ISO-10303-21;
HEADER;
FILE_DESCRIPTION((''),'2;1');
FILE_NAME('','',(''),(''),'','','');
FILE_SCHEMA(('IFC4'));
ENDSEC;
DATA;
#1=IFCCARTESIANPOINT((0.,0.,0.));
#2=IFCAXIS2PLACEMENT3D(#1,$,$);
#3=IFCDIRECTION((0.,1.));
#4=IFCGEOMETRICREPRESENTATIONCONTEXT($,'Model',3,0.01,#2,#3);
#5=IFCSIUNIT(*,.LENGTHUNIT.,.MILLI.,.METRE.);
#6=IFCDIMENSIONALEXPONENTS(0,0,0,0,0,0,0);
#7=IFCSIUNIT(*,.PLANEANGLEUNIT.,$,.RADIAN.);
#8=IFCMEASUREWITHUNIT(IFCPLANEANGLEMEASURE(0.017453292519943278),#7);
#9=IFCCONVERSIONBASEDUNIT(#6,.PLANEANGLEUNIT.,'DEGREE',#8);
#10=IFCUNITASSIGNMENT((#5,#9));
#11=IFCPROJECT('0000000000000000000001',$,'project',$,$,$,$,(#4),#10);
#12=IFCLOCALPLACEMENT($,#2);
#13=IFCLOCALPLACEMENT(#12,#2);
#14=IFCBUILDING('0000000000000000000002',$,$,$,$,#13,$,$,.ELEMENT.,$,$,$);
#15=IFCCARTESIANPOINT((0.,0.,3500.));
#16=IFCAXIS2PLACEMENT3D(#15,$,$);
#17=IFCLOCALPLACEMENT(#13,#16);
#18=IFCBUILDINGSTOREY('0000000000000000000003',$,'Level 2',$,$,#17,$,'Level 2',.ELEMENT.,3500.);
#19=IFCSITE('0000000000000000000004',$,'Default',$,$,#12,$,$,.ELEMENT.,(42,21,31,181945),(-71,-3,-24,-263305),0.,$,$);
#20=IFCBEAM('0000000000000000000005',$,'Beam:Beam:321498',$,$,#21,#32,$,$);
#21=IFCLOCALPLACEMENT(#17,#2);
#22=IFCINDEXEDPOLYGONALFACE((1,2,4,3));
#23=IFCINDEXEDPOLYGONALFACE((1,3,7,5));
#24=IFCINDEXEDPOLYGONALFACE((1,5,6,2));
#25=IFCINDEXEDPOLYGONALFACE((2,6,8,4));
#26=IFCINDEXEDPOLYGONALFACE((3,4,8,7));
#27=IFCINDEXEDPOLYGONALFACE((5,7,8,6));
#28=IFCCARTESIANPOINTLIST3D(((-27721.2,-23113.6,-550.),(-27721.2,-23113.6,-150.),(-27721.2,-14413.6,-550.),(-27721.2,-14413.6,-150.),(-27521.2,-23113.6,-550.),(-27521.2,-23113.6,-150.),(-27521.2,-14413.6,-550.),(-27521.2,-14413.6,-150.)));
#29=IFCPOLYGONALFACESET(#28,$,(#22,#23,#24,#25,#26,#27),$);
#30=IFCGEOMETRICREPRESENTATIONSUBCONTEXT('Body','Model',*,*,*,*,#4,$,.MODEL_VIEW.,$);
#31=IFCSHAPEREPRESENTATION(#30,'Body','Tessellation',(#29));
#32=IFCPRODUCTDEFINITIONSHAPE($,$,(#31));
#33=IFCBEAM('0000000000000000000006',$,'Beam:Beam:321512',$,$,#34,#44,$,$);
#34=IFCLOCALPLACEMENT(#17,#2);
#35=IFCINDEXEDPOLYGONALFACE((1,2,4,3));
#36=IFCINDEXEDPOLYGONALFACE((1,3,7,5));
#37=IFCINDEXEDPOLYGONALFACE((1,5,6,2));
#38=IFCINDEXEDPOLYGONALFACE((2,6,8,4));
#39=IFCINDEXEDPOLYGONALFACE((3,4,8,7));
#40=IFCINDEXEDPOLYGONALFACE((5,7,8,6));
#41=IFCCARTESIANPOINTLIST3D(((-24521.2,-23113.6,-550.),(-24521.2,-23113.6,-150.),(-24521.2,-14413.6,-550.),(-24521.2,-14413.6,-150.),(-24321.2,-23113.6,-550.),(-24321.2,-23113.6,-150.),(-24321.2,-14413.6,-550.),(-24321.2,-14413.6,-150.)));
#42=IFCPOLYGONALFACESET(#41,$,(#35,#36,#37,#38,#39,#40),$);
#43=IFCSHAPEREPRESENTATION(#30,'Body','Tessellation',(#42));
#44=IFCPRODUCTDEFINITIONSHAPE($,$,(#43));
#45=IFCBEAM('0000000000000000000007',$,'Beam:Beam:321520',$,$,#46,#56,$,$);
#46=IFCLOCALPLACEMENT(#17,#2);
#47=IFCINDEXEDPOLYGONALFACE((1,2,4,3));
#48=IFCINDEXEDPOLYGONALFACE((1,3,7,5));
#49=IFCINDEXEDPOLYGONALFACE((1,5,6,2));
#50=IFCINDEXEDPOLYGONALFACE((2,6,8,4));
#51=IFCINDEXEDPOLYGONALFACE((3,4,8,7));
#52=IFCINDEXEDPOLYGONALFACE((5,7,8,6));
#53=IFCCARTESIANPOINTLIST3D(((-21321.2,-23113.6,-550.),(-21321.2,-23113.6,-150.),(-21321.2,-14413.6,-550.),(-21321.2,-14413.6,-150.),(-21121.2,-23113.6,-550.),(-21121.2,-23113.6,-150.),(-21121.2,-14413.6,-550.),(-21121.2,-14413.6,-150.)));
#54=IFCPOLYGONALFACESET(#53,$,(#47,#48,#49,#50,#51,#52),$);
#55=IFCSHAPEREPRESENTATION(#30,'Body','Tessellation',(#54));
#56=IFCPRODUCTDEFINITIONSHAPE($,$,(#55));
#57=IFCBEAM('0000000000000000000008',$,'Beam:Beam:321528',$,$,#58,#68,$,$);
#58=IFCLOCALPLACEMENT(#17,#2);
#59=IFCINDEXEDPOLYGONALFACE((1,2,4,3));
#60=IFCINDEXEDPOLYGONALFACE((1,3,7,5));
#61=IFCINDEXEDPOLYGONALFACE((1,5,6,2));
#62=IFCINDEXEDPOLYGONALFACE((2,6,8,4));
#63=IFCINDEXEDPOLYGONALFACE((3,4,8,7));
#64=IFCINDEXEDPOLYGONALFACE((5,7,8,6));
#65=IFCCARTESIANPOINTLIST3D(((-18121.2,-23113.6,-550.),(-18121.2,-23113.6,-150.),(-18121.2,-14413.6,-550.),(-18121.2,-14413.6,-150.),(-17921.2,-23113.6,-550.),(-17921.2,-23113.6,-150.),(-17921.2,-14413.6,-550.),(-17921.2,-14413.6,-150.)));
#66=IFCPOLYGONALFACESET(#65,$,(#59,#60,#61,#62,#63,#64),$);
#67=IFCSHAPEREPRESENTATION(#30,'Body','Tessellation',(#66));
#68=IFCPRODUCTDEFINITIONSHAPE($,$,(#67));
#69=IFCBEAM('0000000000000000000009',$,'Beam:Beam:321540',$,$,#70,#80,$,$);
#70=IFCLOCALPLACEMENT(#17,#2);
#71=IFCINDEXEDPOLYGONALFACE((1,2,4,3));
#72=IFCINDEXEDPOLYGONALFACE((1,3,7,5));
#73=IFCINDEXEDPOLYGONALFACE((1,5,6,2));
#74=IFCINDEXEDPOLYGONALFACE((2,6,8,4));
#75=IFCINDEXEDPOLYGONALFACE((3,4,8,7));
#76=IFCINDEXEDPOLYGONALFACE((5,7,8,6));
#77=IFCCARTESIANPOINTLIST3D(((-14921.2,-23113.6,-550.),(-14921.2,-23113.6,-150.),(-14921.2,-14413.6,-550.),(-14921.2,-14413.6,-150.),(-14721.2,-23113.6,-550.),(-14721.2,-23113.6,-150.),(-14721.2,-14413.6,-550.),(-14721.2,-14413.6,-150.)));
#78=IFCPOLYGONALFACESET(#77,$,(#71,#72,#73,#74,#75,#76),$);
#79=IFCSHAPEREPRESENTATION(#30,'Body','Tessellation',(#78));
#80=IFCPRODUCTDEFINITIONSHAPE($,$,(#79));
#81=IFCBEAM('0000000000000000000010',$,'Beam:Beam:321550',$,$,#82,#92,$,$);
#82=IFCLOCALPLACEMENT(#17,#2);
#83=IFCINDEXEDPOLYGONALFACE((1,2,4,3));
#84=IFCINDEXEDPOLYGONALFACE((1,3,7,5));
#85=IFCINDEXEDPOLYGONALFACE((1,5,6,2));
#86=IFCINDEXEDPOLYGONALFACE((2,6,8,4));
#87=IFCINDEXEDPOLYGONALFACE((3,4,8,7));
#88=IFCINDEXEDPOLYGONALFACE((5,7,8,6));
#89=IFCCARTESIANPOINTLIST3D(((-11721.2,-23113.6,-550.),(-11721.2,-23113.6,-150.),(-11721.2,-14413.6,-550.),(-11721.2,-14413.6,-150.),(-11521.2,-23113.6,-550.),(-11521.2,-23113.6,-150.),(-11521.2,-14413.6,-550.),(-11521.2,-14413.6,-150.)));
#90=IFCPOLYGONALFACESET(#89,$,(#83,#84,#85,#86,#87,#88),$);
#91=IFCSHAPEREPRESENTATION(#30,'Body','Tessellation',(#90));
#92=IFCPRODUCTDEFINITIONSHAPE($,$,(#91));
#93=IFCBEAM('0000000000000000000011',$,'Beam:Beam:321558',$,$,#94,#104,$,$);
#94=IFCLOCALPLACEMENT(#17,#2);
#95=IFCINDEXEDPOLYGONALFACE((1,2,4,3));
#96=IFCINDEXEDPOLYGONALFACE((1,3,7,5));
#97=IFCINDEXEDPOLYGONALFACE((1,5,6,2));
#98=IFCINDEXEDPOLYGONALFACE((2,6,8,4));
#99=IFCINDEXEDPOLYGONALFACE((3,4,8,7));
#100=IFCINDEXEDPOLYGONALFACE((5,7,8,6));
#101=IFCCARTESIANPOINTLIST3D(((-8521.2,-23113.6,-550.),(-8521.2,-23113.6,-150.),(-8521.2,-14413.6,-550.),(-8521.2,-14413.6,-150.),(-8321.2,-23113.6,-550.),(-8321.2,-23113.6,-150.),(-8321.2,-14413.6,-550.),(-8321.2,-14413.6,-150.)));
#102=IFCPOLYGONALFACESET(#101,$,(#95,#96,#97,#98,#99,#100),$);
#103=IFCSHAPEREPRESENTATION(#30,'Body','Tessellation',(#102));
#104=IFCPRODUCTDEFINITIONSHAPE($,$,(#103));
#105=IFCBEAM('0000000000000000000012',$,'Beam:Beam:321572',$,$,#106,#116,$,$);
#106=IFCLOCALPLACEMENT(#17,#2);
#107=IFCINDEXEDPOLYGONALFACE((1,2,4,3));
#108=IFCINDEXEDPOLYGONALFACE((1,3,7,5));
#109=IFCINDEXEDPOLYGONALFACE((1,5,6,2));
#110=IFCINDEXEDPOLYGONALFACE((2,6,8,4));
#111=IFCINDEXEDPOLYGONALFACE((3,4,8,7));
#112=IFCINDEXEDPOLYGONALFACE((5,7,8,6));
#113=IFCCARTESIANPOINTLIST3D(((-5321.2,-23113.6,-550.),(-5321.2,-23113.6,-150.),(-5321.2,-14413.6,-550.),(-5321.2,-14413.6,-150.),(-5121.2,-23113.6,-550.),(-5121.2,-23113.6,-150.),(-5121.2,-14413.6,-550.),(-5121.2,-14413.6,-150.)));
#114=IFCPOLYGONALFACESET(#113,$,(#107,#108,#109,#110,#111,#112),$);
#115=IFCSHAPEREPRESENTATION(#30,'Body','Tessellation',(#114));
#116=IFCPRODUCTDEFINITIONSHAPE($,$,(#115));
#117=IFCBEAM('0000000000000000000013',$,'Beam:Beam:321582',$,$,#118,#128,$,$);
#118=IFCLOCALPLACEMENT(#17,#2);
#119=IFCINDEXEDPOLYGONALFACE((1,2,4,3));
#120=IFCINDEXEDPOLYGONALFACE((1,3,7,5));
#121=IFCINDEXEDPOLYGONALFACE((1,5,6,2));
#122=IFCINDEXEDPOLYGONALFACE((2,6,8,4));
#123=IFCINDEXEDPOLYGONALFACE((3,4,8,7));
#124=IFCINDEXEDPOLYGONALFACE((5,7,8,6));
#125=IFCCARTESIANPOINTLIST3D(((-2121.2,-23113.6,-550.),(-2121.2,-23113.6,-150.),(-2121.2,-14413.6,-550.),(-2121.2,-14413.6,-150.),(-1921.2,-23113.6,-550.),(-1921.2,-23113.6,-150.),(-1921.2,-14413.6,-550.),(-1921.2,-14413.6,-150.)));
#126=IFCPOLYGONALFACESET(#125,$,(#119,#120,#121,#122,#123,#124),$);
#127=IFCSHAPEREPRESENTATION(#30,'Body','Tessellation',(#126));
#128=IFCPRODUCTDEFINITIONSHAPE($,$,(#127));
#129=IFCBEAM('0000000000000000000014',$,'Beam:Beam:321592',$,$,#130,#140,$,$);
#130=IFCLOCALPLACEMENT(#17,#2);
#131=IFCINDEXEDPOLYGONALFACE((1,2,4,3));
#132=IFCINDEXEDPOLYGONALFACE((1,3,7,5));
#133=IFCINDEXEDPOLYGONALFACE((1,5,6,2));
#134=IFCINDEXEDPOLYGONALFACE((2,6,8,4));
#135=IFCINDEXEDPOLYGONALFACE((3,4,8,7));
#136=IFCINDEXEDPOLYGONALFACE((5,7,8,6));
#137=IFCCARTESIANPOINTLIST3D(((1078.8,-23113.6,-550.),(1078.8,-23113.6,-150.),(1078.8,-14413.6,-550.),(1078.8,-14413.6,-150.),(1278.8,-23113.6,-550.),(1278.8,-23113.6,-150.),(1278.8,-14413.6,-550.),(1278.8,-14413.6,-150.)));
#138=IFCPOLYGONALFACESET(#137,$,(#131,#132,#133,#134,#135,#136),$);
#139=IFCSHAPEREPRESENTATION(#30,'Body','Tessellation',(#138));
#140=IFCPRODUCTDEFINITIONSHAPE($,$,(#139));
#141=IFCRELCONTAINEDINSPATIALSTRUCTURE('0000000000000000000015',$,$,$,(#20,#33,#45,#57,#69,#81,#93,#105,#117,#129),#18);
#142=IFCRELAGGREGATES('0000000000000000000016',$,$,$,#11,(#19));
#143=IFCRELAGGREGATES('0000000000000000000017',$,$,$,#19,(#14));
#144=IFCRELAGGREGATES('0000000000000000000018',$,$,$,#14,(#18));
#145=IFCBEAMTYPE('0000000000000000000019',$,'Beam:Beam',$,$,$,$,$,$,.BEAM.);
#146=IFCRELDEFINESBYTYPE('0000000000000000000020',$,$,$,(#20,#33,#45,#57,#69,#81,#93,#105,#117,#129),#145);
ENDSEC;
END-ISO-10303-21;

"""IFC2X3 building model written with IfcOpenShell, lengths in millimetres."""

from ifc_helpers import new_model, entity, si_unit, converted_unit, direction, frame, frame_2d, origin, place, context, subcontext, project, spatial, rectangle, extrude, type_object, element, save


model = new_model("IFC2X3")

# Units and contexts
model_context = context("Model", 3, precision=0.01, world=origin(), true_north=direction((0.0, 1.0)))
body_context = subcontext(model_context, "Body", "Model", "MODEL_VIEW")
ifc_project = project(units=[si_unit("LENGTHUNIT", "METRE", prefix="MILLI"), converted_unit("PLANEANGLEUNIT", "DEGREE", entity("IfcPlaneAngleMeasure", 0.017453292519943278), si_unit("PLANEANGLEUNIT", "RADIAN"), dimensions=[0, 0, 0, 0, 0, 0, 0])], contexts=[model_context])

# Site, building, storey
site_placement = place(None, origin())
site = spatial("IfcSite", under=ifc_project, at=site_placement, Name="Default", CompositionType="ELEMENT", RefLatitude=(42, 21, 31, 181945), RefLongitude=(-71, -3, -24, -263305), RefElevation=0.0)
building_placement = place(site_placement, origin())
building = spatial("IfcBuilding", under=site, at=building_placement, CompositionType="ELEMENT")
storey_placement = place(building_placement, frame((0.0, 0.0, 3500.0)))
storey = spatial("IfcBuildingStorey", under=building, at=storey_placement, Name="Level 2", LongName="Level 2", CompositionType="ELEMENT", Elevation=3500.0)

# Beams
beam_type = type_object("IfcBeamType", Name="Beam:Beam", PredefinedType="BEAM")
beam_1_placement = place(storey_placement, frame((-27646.2, -14413.6, -150.0), z_axis=(0.0, 0.0, 1.0), x_axis=(0.0, -1.0, 0.0)))
element("IfcBeam", 1, at=beam_1_placement, inside=storey, type_object=beam_type, Name="Beam:Beam:321498", context=body_context, shape_type="SweptSolid", body=[
    extrude(rectangle(XDim=400.0, YDim=200.0, at=frame_2d((0.0, 0.0), x_axis=(1.0, 0.0))), frame((0.0, 25.0, -200.0), z_axis=(1.0, 0.0, 0.0), x_axis=(0.0, 0.0, -1.0)), (0.0, 0.0, 1.0), 8700.0),
])
for number, where, z_axis, x_axis, name in (
    (2, (-24446.2, -14413.6, -150.0), (0.0, 0.0, 1.0), (0.0, -1.0, 0.0), "Beam:Beam:321512"),
    (3, (-21246.2, -14413.6, -150.0), (0.0, 0.0, 1.0), (0.0, -1.0, 0.0), "Beam:Beam:321520"),
):
    element("IfcBeam", number, at=place(storey_placement, frame(where, z_axis=z_axis, x_axis=x_axis)), inside=storey, type_object=beam_type, Name=name, context=body_context, shape_type="SweptSolid", body=[
        extrude(rectangle(XDim=400.0, YDim=200.0, at=frame_2d((0.0, 0.0), x_axis=(1.0, 0.0))), frame((0.0, 25.0, -200.0), z_axis=(1.0, 0.0, 0.0), x_axis=(0.0, 0.0, -1.0)), (0.0, 0.0, 1.0), 8700.0),
    ])
for number, where, z_axis, x_axis, name in (
    (4, (-18046.2, -14413.6, -150.0), (0.0, 0.0, 1.0), (0.0, -1.0, 0.0), "Beam:Beam:321528"),
    (5, (-14846.2, -14413.6, -150.0), (0.0, 0.0, 1.0), (0.0, -1.0, 0.0), "Beam:Beam:321540"),
):
    element("IfcBeam", number, at=place(storey_placement, frame(where, z_axis=z_axis, x_axis=x_axis)), inside=storey, type_object=beam_type, Name=name, context=body_context, shape_type="SweptSolid", body=[
        extrude(rectangle(XDim=400.0, YDim=200.0, at=frame_2d((0.0, 0.0), x_axis=(1.0, 0.0))), frame((0.0, 25.0, -200.0), z_axis=(1.0, 0.0, 0.0), x_axis=(0.0, 0.0, -1.0)), (0.0, 0.0, 1.0), 8700.0),
    ])
beam_2_placement = place(storey_placement, frame((-11646.2, -14413.6, -150.0), z_axis=(0.0, 0.0, 1.0), x_axis=(0.0, -1.0, 0.0)))
element("IfcBeam", 6, at=beam_2_placement, inside=storey, type_object=beam_type, Name="Beam:Beam:321550", context=body_context, shape_type="SweptSolid", body=[
    extrude(rectangle(XDim=400.0, YDim=200.0, at=frame_2d((0.0, 0.0), x_axis=(1.0, 0.0))), frame((0.0, 25.0, -200.0), z_axis=(1.0, 0.0, 0.0), x_axis=(0.0, 0.0, -1.0)), (0.0, 0.0, 1.0), 8700.0),
])
for number, where, z_axis, x_axis, name in (
    (7, (-8446.2, -14413.6, -150.0), (0.0, 0.0, 1.0), (0.0, -1.0, 0.0), "Beam:Beam:321558"),
    (8, (-5246.2, -14413.6, -150.0), (0.0, 0.0, 1.0), (0.0, -1.0, 0.0), "Beam:Beam:321572"),
):
    element("IfcBeam", number, at=place(storey_placement, frame(where, z_axis=z_axis, x_axis=x_axis)), inside=storey, type_object=beam_type, Name=name, context=body_context, shape_type="SweptSolid", body=[
        extrude(rectangle(XDim=400.0, YDim=200.0, at=frame_2d((0.0, 0.0), x_axis=(1.0, 0.0))), frame((0.0, 25.0, -200.0), z_axis=(1.0, 0.0, 0.0), x_axis=(0.0, 0.0, -1.0)), (0.0, 0.0, 1.0), 8700.0),
    ])
beam_3_placement = place(storey_placement, frame((-2046.2, -14413.6, -150.0), z_axis=(0.0, 0.0, 1.0), x_axis=(0.0, -1.0, 0.0)))
element("IfcBeam", 9, at=beam_3_placement, inside=storey, type_object=beam_type, Name="Beam:Beam:321582", context=body_context, shape_type="SweptSolid", body=[
    extrude(rectangle(XDim=400.0, YDim=200.0, at=frame_2d((0.0, 0.0), x_axis=(1.0, 0.0))), frame((0.0, 25.0, -200.0), z_axis=(1.0, 0.0, 0.0), x_axis=(0.0, 0.0, -1.0)), (0.0, 0.0, 1.0), 8700.0),
])
beam_4_placement = place(storey_placement, frame((1153.8, -14413.6, -150.0), z_axis=(0.0, 0.0, 1.0), x_axis=(0.0, -1.0, 0.0)))
element("IfcBeam", 10, at=beam_4_placement, inside=storey, type_object=beam_type, Name="Beam:Beam:321592", context=body_context, shape_type="SweptSolid", body=[
    extrude(rectangle(XDim=400.0, YDim=200.0, at=frame_2d((0.0, 0.0), x_axis=(1.0, 0.0))), frame((0.0, 25.0, -200.0), z_axis=(1.0, 0.0, 0.0), x_axis=(0.0, 0.0, -1.0)), (0.0, 0.0, 1.0), 8700.0),
])

save(model, "model.ifc")
